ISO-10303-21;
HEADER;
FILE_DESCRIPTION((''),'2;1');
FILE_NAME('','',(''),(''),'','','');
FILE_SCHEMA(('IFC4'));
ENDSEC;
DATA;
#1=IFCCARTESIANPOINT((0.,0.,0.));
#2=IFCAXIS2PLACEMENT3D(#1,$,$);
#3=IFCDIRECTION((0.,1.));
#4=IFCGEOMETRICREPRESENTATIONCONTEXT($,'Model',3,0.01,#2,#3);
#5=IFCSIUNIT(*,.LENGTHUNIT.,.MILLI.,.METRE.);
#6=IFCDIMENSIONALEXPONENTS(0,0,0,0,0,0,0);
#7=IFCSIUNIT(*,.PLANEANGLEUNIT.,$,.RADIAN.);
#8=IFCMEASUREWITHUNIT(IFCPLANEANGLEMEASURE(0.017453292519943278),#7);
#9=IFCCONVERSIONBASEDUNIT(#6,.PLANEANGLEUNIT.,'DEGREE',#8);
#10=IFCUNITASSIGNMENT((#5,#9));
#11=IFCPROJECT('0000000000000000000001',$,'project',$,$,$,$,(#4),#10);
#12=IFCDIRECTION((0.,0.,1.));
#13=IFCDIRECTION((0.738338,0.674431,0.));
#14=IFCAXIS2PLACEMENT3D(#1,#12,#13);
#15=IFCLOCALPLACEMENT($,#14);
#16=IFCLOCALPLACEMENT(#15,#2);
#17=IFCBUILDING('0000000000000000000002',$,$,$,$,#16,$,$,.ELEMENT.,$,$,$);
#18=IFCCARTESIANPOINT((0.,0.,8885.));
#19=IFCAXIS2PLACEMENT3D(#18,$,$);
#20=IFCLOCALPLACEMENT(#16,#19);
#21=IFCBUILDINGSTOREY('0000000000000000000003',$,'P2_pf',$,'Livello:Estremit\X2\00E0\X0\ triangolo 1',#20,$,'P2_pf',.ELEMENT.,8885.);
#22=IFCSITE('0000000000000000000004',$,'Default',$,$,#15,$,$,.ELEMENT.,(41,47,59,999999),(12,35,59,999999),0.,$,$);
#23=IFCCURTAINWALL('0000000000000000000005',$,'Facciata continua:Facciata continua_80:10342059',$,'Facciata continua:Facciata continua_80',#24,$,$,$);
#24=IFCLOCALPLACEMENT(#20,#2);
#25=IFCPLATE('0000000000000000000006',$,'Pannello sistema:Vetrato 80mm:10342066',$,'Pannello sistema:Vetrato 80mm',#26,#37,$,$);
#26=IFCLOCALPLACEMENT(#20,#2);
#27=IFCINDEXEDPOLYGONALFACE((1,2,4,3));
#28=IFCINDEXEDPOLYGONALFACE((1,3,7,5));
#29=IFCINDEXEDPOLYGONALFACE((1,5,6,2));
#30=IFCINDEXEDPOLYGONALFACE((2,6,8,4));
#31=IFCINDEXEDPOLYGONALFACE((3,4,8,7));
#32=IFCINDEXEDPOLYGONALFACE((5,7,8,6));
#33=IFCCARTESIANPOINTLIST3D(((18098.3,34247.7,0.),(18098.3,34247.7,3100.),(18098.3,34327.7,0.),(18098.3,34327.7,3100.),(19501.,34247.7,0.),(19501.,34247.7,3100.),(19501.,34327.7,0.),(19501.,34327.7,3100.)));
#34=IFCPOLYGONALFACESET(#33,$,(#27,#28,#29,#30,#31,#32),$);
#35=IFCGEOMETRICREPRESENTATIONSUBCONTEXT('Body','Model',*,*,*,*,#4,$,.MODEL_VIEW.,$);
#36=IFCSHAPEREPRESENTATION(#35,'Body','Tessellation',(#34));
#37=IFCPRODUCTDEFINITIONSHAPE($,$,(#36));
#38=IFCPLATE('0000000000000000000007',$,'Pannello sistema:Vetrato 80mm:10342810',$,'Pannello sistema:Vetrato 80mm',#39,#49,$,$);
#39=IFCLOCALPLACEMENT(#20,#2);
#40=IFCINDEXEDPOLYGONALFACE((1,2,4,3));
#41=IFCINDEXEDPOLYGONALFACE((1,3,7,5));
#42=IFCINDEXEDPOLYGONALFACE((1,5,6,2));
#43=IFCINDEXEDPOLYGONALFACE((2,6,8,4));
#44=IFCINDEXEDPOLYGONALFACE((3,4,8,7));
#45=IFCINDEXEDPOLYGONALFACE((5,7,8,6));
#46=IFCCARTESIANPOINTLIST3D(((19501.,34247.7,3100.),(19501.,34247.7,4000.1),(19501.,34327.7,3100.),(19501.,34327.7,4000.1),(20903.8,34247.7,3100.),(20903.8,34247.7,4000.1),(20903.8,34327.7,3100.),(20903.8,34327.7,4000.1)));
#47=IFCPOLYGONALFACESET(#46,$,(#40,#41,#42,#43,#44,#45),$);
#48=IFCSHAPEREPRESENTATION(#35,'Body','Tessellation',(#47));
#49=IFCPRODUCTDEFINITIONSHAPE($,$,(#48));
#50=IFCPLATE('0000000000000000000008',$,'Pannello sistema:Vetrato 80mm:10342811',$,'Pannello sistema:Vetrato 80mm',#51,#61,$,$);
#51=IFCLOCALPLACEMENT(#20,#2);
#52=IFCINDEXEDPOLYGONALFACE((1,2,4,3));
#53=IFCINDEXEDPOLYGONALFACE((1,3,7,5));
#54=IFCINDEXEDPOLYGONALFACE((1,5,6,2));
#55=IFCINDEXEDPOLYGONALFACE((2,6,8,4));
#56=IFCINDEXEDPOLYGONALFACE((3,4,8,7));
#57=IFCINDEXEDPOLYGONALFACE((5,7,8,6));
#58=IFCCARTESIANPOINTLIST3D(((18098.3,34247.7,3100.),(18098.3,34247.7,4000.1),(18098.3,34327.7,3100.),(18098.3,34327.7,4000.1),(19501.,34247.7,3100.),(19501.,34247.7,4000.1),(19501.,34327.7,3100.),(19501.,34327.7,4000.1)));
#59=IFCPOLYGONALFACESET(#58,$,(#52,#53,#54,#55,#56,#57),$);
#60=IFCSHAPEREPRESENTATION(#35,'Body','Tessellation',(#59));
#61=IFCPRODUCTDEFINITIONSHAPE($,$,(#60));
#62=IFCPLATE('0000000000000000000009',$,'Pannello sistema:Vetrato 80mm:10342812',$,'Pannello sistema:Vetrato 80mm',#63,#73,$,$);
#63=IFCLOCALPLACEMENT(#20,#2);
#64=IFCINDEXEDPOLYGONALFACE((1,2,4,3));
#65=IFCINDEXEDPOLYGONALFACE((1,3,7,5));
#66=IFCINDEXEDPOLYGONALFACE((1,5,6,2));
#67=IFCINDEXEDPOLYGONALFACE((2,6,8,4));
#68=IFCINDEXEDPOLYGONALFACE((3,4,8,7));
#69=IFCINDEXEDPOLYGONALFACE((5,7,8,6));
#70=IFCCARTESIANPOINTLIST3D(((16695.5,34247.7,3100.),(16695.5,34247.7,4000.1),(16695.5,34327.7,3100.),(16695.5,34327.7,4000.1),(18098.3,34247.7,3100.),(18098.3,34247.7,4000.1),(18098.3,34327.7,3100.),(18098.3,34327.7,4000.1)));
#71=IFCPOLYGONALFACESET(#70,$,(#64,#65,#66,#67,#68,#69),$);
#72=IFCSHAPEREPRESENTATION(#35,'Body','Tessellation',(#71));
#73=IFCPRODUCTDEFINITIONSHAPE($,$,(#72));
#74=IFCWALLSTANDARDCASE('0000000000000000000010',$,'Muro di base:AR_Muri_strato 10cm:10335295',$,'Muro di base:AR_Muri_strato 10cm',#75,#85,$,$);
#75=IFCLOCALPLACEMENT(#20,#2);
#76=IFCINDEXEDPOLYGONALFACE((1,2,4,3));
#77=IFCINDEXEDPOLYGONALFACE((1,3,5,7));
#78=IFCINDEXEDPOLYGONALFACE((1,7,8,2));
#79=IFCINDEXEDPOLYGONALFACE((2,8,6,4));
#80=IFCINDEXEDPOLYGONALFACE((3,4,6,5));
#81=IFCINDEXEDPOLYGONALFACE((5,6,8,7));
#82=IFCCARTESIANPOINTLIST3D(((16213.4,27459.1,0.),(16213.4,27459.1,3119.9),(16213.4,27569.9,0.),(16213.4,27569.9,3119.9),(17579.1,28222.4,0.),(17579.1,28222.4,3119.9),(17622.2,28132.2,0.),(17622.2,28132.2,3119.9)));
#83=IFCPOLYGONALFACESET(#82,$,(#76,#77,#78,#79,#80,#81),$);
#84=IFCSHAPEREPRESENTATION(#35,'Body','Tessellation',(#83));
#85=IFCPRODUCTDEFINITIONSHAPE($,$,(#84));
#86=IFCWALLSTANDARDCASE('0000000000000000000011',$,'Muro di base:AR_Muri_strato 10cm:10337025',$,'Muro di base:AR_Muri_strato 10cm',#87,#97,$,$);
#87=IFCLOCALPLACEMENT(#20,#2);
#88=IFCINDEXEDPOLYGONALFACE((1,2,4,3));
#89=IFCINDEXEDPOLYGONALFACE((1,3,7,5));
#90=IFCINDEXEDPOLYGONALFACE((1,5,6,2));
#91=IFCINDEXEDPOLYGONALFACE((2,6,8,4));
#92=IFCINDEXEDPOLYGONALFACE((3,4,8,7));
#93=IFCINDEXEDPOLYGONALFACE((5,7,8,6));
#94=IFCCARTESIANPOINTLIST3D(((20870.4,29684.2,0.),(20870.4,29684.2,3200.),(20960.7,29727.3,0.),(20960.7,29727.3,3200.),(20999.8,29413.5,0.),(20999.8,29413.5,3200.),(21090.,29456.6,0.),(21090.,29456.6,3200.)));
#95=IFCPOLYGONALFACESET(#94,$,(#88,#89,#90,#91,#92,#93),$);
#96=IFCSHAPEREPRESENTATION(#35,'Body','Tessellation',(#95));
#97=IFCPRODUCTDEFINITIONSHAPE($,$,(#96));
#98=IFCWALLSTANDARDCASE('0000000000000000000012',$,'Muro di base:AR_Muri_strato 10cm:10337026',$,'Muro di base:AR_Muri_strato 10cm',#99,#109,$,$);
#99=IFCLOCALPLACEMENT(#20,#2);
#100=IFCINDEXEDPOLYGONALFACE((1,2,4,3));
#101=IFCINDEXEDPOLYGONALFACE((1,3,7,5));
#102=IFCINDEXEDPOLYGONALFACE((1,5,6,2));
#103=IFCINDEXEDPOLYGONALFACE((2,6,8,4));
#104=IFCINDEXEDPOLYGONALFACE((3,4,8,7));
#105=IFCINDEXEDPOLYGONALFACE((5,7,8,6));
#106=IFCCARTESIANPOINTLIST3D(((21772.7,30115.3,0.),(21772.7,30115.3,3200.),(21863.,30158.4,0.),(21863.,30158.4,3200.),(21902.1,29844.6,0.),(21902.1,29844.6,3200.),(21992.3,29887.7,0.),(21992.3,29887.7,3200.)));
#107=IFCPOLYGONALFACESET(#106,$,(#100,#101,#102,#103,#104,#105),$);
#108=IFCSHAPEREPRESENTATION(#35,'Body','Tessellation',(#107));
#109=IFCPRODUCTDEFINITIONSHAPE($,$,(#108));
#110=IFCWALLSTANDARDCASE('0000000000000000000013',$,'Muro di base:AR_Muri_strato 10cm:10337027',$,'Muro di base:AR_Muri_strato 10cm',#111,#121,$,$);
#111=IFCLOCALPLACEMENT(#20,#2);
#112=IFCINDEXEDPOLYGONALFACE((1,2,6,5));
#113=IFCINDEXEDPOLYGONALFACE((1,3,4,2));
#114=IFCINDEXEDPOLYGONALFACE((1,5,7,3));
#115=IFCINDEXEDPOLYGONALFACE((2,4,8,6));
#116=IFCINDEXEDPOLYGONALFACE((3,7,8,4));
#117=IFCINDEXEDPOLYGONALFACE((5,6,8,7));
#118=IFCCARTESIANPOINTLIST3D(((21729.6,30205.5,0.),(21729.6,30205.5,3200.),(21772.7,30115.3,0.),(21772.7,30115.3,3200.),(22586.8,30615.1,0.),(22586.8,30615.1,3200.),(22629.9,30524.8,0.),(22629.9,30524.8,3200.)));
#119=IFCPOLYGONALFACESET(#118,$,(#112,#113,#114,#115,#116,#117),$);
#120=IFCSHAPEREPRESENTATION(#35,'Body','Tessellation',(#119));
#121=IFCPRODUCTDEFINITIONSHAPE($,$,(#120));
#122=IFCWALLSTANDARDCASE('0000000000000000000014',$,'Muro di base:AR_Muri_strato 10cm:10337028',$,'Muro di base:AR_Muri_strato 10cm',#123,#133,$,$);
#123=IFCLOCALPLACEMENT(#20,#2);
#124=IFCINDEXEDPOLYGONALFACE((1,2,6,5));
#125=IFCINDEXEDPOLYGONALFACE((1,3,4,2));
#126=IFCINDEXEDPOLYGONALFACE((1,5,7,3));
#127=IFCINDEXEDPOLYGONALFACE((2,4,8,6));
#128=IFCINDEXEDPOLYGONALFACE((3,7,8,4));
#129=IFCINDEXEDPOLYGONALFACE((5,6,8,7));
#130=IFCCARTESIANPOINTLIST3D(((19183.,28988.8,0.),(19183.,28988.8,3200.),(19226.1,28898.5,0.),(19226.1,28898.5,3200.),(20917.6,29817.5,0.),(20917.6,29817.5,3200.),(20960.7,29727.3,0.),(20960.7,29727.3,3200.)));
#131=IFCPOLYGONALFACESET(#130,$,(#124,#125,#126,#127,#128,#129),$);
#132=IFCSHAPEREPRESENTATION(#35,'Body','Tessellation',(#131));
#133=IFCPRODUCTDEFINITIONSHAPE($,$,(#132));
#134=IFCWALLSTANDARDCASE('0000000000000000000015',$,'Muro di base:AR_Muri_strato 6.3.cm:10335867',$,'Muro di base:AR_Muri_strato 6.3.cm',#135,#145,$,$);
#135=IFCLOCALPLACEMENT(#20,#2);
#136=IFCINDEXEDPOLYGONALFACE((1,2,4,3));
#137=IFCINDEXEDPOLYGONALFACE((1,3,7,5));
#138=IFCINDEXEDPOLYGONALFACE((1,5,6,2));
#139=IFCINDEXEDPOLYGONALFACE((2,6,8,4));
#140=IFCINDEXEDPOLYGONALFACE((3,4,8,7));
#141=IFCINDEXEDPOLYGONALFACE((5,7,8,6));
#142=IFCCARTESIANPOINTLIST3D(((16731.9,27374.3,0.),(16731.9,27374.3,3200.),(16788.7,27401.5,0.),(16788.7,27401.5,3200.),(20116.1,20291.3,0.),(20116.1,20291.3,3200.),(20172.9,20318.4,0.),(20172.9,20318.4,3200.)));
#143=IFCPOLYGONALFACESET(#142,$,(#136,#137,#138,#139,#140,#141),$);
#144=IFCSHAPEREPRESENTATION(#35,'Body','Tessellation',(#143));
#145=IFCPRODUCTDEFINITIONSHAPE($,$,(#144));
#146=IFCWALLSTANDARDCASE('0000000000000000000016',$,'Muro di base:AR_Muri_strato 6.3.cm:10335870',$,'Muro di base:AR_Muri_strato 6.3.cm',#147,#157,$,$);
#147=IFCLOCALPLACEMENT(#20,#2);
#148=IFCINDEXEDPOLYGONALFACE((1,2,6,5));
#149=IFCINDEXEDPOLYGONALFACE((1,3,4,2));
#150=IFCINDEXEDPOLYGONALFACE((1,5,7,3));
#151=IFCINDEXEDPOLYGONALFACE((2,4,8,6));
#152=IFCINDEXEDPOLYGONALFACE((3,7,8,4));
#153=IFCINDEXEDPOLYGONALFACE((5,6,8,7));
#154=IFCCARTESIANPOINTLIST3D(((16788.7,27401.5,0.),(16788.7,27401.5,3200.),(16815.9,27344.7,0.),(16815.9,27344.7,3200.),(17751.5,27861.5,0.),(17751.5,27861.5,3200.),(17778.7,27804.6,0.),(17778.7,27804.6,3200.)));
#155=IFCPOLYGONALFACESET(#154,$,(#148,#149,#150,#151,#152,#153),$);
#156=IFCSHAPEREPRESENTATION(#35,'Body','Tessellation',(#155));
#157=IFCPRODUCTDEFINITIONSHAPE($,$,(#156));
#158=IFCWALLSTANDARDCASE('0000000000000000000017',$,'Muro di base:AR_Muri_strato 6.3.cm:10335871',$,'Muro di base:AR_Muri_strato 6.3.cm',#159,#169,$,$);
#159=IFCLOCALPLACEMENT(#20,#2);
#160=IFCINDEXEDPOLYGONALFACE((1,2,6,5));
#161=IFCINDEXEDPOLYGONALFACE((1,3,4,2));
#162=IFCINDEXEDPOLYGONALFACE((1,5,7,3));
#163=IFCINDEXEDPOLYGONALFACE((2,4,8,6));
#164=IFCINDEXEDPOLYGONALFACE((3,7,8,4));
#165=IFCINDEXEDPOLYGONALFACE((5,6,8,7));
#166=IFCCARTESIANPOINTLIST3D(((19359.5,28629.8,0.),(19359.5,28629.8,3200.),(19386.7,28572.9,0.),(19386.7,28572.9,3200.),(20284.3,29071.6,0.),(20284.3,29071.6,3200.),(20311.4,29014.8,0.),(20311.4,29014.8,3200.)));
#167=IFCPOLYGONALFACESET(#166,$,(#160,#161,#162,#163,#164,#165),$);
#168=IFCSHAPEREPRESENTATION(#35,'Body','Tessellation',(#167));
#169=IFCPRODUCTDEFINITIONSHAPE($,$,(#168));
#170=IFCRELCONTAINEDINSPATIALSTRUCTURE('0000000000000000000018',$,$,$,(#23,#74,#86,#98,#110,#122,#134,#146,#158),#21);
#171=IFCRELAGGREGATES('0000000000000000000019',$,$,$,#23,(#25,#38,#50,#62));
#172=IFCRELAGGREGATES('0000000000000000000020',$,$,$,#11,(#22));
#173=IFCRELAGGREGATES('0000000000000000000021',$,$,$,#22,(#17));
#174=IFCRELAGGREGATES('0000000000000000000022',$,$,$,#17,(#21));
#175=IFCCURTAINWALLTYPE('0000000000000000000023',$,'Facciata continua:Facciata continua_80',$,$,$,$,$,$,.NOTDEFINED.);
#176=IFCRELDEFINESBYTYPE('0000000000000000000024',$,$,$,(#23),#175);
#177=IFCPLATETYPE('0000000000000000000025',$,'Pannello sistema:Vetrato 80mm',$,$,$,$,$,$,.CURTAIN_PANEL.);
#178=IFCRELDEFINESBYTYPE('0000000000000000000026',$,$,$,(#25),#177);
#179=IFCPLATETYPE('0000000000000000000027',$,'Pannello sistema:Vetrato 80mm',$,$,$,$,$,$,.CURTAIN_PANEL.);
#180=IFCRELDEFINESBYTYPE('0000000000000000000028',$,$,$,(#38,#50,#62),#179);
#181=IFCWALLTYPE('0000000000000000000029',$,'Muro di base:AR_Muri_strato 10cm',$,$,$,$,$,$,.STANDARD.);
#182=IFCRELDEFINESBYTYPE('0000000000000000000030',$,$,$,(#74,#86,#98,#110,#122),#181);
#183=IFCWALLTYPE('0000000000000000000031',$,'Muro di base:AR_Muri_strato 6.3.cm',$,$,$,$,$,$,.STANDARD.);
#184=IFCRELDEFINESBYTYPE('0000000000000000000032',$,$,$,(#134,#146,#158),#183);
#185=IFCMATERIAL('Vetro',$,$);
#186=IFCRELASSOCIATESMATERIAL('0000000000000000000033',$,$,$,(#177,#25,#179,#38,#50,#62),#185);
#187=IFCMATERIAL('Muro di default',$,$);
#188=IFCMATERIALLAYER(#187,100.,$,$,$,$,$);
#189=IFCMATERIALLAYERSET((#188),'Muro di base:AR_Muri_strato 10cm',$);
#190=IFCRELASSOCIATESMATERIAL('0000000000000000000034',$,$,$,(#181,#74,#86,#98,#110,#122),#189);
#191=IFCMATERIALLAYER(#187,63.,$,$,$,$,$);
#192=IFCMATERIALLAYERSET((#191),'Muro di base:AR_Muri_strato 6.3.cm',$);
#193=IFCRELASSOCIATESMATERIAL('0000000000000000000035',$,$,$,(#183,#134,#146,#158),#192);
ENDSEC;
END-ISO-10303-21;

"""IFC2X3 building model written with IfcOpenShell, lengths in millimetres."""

from ifc_helpers import new_model, entity, si_unit, converted_unit, direction, frame, frame_2d, origin, origin_2d_with_axis, place, context, subcontext, project, spatial, polyline, rectangle, outline, extrude, source, transform, mapped, material, layer, layer_set, layer_usage, type_object, type_shapes, element, aggregate, save


model = new_model("IFC2X3")

# Units and contexts
model_context = context("Model", 3, precision=0.01, world=origin(), true_north=direction((0.0, 1.0)))
body_context = subcontext(model_context, "Body", "Model", "MODEL_VIEW")
ifc_project = project(units=[si_unit("LENGTHUNIT", "METRE", prefix="MILLI"), converted_unit("PLANEANGLEUNIT", "DEGREE", entity("IfcPlaneAngleMeasure", 0.017453292519943278), si_unit("PLANEANGLEUNIT", "RADIAN"), dimensions=[0, 0, 0, 0, 0, 0, 0])], contexts=[model_context])

# Site, building, storey
site_placement = place(None, frame((0.0, 0.0, 0.0), z_axis=(0.0, 0.0, 1.0), x_axis=(0.738338, 0.674431, 0.0)))
site = spatial("IfcSite", under=ifc_project, at=site_placement, Name="Default", CompositionType="ELEMENT", RefLatitude=(41, 47, 59, 999999), RefLongitude=(12, 35, 59, 999999), RefElevation=0.0)
building_placement = place(site_placement, origin())
building = spatial("IfcBuilding", under=site, at=building_placement, CompositionType="ELEMENT")
storey_placement = place(building_placement, frame((0.0, 0.0, 8885.0)))
storey = spatial("IfcBuildingStorey", under=building, at=storey_placement, Name="P2_pf", ObjectType="Livello:Estremità triangolo 1", LongName="P2_pf", CompositionType="ELEMENT", Elevation=8885.0)

# Curtain wall, plates
curtain_wall_type = type_object("IfcCurtainWallType", Name="Facciata continua:Facciata continua_80", PredefinedType="NOTDEFINED")
ifc_material_1 = material(Name="Vetro")
curtain_wall_1_placement = place(storey_placement, frame((0.0, 0.0, -8885.0)))
curtain_wall_1 = element("IfcCurtainWall", 1, at=curtain_wall_1_placement, inside=storey, type_object=curtain_wall_type, Name="Facciata continua:Facciata continua_80:10342059", ObjectType="Facciata continua:Facciata continua_80")
plate_type_1 = type_object("IfcPlateType", Name="Pannello sistema:Vetrato 80mm", PredefinedType="CURTAIN_PANEL", material=ifc_material_1)
shared_shape_1 = source(origin(), body_context, "Body", "SweptSolid", [
    extrude(rectangle(XDim=80.0, YDim=1402.8, at=origin_2d_with_axis()), frame((0.0, -40.0, 0.0), z_axis=(0.0, 0.0, 1.0), x_axis=(0.0, 1.0, 0.0)), (0.0, 0.0, 1.0), 3100.0),
])
type_shapes(plate_type_1, [shared_shape_1])
plate_1_placement = place(curtain_wall_1_placement, frame((18799.6, 34247.7, 8885.0), z_axis=(0.0, 0.0, 1.0), x_axis=(-1.0, 0.0, 0.0)))
plate_1 = element("IfcPlate", 2, at=plate_1_placement, type_object=plate_type_1, material=ifc_material_1, Name="Pannello sistema:Vetrato 80mm:10342066", ObjectType="Pannello sistema:Vetrato 80mm", context=body_context, shape_type="MappedRepresentation", body=[
    mapped(shared_shape_1, transform((0.0, 0.0, 0.0), scale=1.0)),
])
plate_type_2 = type_object("IfcPlateType", Name="Pannello sistema:Vetrato 80mm", PredefinedType="CURTAIN_PANEL", material=ifc_material_1)
shared_shape_2 = source(origin(), body_context, "Body", "SweptSolid", [
    extrude(rectangle(XDim=80.0, YDim=1402.8, at=origin_2d_with_axis()), frame((0.0, -40.0, 0.0), z_axis=(0.0, 0.0, 1.0), x_axis=(0.0, 1.0, 0.0)), (0.0, 0.0, 1.0), 900.1),
])
type_shapes(plate_type_2, [shared_shape_2])
plate_2_placement = place(curtain_wall_1_placement, frame((20202.4, 34247.7, 11985.0), z_axis=(0.0, 0.0, 1.0), x_axis=(-1.0, 0.0, 0.0)))
plate_2 = element("IfcPlate", 3, at=plate_2_placement, type_object=plate_type_2, material=ifc_material_1, Name="Pannello sistema:Vetrato 80mm:10342810", ObjectType="Pannello sistema:Vetrato 80mm", context=body_context, shape_type="MappedRepresentation", body=[
    mapped(shared_shape_2, transform((0.0, 0.0, 0.0), scale=1.0)),
])
plate_3_placement = place(curtain_wall_1_placement, frame((18799.6, 34247.7, 11985.0), z_axis=(0.0, 0.0, 1.0), x_axis=(-1.0, 0.0, 0.0)))
plate_3 = element("IfcPlate", 4, at=plate_3_placement, type_object=plate_type_2, material=ifc_material_1, Name="Pannello sistema:Vetrato 80mm:10342811", ObjectType="Pannello sistema:Vetrato 80mm", context=body_context, shape_type="MappedRepresentation", body=[
    mapped(shared_shape_2, transform((0.0, 0.0, 0.0), scale=1.0)),
])
plate_4_placement = place(curtain_wall_1_placement, frame((17396.9, 34247.7, 11985.0), z_axis=(0.0, 0.0, 1.0), x_axis=(-1.0, 0.0, 0.0)))
plate_4 = element("IfcPlate", 5, at=plate_4_placement, type_object=plate_type_2, material=ifc_material_1, Name="Pannello sistema:Vetrato 80mm:10342812", ObjectType="Pannello sistema:Vetrato 80mm", context=body_context, shape_type="MappedRepresentation", body=[
    mapped(shared_shape_2, transform((0.0, 0.0, 0.0), scale=1.0)),
])
aggregate(curtain_wall_1, [plate_1, plate_2, plate_3, plate_4])

# Walls
ifc_material_2 = material(Name="Muro di default")
ifc_layer_1 = layer(ifc_material_2, 100.0)
ifc_layer_set_1 = layer_set([ifc_layer_1], Name="Muro di base:AR_Muri_strato 10cm")
ifc_layer_usage_1 = layer_usage(ifc_layer_set_1, "AXIS2", "NEGATIVE", 50.0)
wall_type_1 = type_object("IfcWallType", Name="Muro di base:AR_Muri_strato 10cm", PredefinedType="STANDARD", material=ifc_layer_set_1)
wall_1_placement = place(storey_placement, frame((17600.6, 28177.3, 0.0), z_axis=(0.0, 0.0, 1.0), x_axis=(-0.902302, -0.431105, 0.0)))
element("IfcWallStandardCase", 6, at=wall_1_placement, inside=storey, type_object=wall_type_1, material=ifc_layer_usage_1, Name="Muro di base:AR_Muri_strato 10cm:10335295", ObjectType="Muro di base:AR_Muri_strato 10cm", context=body_context, shape_type="SweptSolid", body=[
    extrude(outline(polyline([(1513.5, -50.0), (1561.2, 50.0), (0.0, 50.0), (0.0, -50.0), (1513.5, -50.0)])), origin(), (0.0, 0.0, 1.0), 3119.9),
])
ifc_layer_usage_2 = layer_usage(ifc_layer_set_1, "AXIS2", "NEGATIVE", 50.0)
wall_2_placement = place(storey_placement, frame((21044.9, 29435.0, 0.0), z_axis=(0.0, 0.0, 1.0), x_axis=(-0.431105, 0.902302, 0.0)))
element("IfcWallStandardCase", 7, at=wall_2_placement, inside=storey, type_object=wall_type_1, material=ifc_layer_usage_2, Name="Muro di base:AR_Muri_strato 10cm:10337025", ObjectType="Muro di base:AR_Muri_strato 10cm", context=body_context, shape_type="SweptSolid", body=[
    extrude(rectangle(XDim=300.0, YDim=100.0, at=frame_2d((150.0, 0.0), x_axis=(-1.0, 0.0))), origin(), (0.0, 0.0, 1.0), 3200.0),
])
ifc_layer_usage_3 = layer_usage(ifc_layer_set_1, "AXIS2", "NEGATIVE", 50.0)
wall_3_placement = place(storey_placement, frame((21817.9, 30136.8, 0.0), z_axis=(0.0, 0.0, 1.0), x_axis=(0.431105, -0.902302, 0.0)))
element("IfcWallStandardCase", 8, at=wall_3_placement, inside=storey, type_object=wall_type_1, material=ifc_layer_usage_3, Name="Muro di base:AR_Muri_strato 10cm:10337026", ObjectType="Muro di base:AR_Muri_strato 10cm", context=body_context, shape_type="SweptSolid", body=[
    extrude(rectangle(XDim=300.0, YDim=100.0, at=frame_2d((150.0, 0.0), x_axis=(-1.0, 0.0))), origin(), (0.0, 0.0, 1.0), 3200.0),
])
ifc_layer_usage_4 = layer_usage(ifc_layer_set_1, "AXIS2", "NEGATIVE", 50.0)
wall_4_placement = place(storey_placement, frame((22608.4, 30569.9, 0.0), z_axis=(0.0, 0.0, 1.0), x_axis=(-0.902302, -0.431105, 0.0)))
element("IfcWallStandardCase", 9, at=wall_4_placement, inside=storey, type_object=wall_type_1, material=ifc_layer_usage_4, Name="Muro di base:AR_Muri_strato 10cm:10337027", ObjectType="Muro di base:AR_Muri_strato 10cm", context=body_context, shape_type="SweptSolid", body=[
    extrude(rectangle(XDim=950.0, YDim=100.0, at=frame_2d((475.0, 0.0), x_axis=(-1.0, 0.0))), origin(), (0.0, 0.0, 1.0), 3200.0),
])
ifc_layer_usage_5 = layer_usage(ifc_layer_set_1, "AXIS2", "NEGATIVE", 50.0)
wall_5_placement = place(storey_placement, frame((20939.1, 29772.4, 0.0), z_axis=(0.0, 0.0, 1.0), x_axis=(-0.902302, -0.431105, 0.0)))
element("IfcWallStandardCase", 10, at=wall_5_placement, inside=storey, type_object=wall_type_1, material=ifc_layer_usage_5, Name="Muro di base:AR_Muri_strato 10cm:10337028", ObjectType="Muro di base:AR_Muri_strato 10cm", context=body_context, shape_type="SweptSolid", body=[
    extrude(rectangle(XDim=1922.4, YDim=100.0, at=frame_2d((961.2, 0.0), x_axis=(-1.0, 0.0))), origin(), (0.0, 0.0, 1.0), 3200.0),
])
ifc_layer_2 = layer(ifc_material_2, 63.0)
ifc_layer_set_2 = layer_set([ifc_layer_2], Name="Muro di base:AR_Muri_strato 6.3.cm")
ifc_layer_usage_6 = layer_usage(ifc_layer_set_2, "AXIS2", "NEGATIVE", 31.5)
wall_type_2 = type_object("IfcWallType", Name="Muro di base:AR_Muri_strato 6.3.cm", PredefinedType="STANDARD", material=ifc_layer_set_2)
wall_6_placement = place(storey_placement, frame((16760.3, 27387.9, 0.0), z_axis=(0.0, 0.0, 1.0), x_axis=(0.431105, -0.902302, 0.0)))
element("IfcWallStandardCase", 11, at=wall_6_placement, inside=storey, type_object=wall_type_2, material=ifc_layer_usage_6, Name="Muro di base:AR_Muri_strato 6.3.cm:10335867", ObjectType="Muro di base:AR_Muri_strato 6.3.cm", context=body_context, shape_type="SweptSolid", body=[
    extrude(rectangle(XDim=7850.0, YDim=63.0, at=frame_2d((3925.0, 0.0), x_axis=(-1.0, 0.0))), origin(), (0.0, 0.0, 1.0), 3200.0),
])
ifc_layer_usage_7 = layer_usage(ifc_layer_set_2, "AXIS2", "NEGATIVE", 31.5)
wall_7_placement = place(storey_placement, frame((17765.1, 27833.1, 0.0), z_axis=(0.0, 0.0, 1.0), x_axis=(-0.902302, -0.431105, 0.0)))
element("IfcWallStandardCase", 12, at=wall_7_placement, inside=storey, type_object=wall_type_2, material=ifc_layer_usage_7, Name="Muro di base:AR_Muri_strato 6.3.cm:10335870", ObjectType="Muro di base:AR_Muri_strato 6.3.cm", context=body_context, shape_type="SweptSolid", body=[
    extrude(rectangle(XDim=1067.0, YDim=63.0, at=frame_2d((533.5, 0.0), x_axis=(-1.0, 0.0))), origin(), (0.0, 0.0, 1.0), 3200.0),
])
ifc_layer_usage_8 = layer_usage(ifc_layer_set_2, "AXIS2", "NEGATIVE", 31.5)
wall_8_placement = place(storey_placement, frame((20297.8, 29043.2, 0.0), z_axis=(0.0, 0.0, 1.0), x_axis=(-0.902302, -0.431105, 0.0)))
element("IfcWallStandardCase", 13, at=wall_8_placement, inside=storey, type_object=wall_type_2, material=ifc_layer_usage_8, Name="Muro di base:AR_Muri_strato 6.3.cm:10335871", ObjectType="Muro di base:AR_Muri_strato 6.3.cm", context=body_context, shape_type="SweptSolid", body=[
    extrude(rectangle(XDim=1024.8, YDim=63.0, at=frame_2d((512.4, 0.0), x_axis=(-1.0, 0.0))), origin(), (0.0, 0.0, 1.0), 3200.0),
])

save(model, "model.ifc")
